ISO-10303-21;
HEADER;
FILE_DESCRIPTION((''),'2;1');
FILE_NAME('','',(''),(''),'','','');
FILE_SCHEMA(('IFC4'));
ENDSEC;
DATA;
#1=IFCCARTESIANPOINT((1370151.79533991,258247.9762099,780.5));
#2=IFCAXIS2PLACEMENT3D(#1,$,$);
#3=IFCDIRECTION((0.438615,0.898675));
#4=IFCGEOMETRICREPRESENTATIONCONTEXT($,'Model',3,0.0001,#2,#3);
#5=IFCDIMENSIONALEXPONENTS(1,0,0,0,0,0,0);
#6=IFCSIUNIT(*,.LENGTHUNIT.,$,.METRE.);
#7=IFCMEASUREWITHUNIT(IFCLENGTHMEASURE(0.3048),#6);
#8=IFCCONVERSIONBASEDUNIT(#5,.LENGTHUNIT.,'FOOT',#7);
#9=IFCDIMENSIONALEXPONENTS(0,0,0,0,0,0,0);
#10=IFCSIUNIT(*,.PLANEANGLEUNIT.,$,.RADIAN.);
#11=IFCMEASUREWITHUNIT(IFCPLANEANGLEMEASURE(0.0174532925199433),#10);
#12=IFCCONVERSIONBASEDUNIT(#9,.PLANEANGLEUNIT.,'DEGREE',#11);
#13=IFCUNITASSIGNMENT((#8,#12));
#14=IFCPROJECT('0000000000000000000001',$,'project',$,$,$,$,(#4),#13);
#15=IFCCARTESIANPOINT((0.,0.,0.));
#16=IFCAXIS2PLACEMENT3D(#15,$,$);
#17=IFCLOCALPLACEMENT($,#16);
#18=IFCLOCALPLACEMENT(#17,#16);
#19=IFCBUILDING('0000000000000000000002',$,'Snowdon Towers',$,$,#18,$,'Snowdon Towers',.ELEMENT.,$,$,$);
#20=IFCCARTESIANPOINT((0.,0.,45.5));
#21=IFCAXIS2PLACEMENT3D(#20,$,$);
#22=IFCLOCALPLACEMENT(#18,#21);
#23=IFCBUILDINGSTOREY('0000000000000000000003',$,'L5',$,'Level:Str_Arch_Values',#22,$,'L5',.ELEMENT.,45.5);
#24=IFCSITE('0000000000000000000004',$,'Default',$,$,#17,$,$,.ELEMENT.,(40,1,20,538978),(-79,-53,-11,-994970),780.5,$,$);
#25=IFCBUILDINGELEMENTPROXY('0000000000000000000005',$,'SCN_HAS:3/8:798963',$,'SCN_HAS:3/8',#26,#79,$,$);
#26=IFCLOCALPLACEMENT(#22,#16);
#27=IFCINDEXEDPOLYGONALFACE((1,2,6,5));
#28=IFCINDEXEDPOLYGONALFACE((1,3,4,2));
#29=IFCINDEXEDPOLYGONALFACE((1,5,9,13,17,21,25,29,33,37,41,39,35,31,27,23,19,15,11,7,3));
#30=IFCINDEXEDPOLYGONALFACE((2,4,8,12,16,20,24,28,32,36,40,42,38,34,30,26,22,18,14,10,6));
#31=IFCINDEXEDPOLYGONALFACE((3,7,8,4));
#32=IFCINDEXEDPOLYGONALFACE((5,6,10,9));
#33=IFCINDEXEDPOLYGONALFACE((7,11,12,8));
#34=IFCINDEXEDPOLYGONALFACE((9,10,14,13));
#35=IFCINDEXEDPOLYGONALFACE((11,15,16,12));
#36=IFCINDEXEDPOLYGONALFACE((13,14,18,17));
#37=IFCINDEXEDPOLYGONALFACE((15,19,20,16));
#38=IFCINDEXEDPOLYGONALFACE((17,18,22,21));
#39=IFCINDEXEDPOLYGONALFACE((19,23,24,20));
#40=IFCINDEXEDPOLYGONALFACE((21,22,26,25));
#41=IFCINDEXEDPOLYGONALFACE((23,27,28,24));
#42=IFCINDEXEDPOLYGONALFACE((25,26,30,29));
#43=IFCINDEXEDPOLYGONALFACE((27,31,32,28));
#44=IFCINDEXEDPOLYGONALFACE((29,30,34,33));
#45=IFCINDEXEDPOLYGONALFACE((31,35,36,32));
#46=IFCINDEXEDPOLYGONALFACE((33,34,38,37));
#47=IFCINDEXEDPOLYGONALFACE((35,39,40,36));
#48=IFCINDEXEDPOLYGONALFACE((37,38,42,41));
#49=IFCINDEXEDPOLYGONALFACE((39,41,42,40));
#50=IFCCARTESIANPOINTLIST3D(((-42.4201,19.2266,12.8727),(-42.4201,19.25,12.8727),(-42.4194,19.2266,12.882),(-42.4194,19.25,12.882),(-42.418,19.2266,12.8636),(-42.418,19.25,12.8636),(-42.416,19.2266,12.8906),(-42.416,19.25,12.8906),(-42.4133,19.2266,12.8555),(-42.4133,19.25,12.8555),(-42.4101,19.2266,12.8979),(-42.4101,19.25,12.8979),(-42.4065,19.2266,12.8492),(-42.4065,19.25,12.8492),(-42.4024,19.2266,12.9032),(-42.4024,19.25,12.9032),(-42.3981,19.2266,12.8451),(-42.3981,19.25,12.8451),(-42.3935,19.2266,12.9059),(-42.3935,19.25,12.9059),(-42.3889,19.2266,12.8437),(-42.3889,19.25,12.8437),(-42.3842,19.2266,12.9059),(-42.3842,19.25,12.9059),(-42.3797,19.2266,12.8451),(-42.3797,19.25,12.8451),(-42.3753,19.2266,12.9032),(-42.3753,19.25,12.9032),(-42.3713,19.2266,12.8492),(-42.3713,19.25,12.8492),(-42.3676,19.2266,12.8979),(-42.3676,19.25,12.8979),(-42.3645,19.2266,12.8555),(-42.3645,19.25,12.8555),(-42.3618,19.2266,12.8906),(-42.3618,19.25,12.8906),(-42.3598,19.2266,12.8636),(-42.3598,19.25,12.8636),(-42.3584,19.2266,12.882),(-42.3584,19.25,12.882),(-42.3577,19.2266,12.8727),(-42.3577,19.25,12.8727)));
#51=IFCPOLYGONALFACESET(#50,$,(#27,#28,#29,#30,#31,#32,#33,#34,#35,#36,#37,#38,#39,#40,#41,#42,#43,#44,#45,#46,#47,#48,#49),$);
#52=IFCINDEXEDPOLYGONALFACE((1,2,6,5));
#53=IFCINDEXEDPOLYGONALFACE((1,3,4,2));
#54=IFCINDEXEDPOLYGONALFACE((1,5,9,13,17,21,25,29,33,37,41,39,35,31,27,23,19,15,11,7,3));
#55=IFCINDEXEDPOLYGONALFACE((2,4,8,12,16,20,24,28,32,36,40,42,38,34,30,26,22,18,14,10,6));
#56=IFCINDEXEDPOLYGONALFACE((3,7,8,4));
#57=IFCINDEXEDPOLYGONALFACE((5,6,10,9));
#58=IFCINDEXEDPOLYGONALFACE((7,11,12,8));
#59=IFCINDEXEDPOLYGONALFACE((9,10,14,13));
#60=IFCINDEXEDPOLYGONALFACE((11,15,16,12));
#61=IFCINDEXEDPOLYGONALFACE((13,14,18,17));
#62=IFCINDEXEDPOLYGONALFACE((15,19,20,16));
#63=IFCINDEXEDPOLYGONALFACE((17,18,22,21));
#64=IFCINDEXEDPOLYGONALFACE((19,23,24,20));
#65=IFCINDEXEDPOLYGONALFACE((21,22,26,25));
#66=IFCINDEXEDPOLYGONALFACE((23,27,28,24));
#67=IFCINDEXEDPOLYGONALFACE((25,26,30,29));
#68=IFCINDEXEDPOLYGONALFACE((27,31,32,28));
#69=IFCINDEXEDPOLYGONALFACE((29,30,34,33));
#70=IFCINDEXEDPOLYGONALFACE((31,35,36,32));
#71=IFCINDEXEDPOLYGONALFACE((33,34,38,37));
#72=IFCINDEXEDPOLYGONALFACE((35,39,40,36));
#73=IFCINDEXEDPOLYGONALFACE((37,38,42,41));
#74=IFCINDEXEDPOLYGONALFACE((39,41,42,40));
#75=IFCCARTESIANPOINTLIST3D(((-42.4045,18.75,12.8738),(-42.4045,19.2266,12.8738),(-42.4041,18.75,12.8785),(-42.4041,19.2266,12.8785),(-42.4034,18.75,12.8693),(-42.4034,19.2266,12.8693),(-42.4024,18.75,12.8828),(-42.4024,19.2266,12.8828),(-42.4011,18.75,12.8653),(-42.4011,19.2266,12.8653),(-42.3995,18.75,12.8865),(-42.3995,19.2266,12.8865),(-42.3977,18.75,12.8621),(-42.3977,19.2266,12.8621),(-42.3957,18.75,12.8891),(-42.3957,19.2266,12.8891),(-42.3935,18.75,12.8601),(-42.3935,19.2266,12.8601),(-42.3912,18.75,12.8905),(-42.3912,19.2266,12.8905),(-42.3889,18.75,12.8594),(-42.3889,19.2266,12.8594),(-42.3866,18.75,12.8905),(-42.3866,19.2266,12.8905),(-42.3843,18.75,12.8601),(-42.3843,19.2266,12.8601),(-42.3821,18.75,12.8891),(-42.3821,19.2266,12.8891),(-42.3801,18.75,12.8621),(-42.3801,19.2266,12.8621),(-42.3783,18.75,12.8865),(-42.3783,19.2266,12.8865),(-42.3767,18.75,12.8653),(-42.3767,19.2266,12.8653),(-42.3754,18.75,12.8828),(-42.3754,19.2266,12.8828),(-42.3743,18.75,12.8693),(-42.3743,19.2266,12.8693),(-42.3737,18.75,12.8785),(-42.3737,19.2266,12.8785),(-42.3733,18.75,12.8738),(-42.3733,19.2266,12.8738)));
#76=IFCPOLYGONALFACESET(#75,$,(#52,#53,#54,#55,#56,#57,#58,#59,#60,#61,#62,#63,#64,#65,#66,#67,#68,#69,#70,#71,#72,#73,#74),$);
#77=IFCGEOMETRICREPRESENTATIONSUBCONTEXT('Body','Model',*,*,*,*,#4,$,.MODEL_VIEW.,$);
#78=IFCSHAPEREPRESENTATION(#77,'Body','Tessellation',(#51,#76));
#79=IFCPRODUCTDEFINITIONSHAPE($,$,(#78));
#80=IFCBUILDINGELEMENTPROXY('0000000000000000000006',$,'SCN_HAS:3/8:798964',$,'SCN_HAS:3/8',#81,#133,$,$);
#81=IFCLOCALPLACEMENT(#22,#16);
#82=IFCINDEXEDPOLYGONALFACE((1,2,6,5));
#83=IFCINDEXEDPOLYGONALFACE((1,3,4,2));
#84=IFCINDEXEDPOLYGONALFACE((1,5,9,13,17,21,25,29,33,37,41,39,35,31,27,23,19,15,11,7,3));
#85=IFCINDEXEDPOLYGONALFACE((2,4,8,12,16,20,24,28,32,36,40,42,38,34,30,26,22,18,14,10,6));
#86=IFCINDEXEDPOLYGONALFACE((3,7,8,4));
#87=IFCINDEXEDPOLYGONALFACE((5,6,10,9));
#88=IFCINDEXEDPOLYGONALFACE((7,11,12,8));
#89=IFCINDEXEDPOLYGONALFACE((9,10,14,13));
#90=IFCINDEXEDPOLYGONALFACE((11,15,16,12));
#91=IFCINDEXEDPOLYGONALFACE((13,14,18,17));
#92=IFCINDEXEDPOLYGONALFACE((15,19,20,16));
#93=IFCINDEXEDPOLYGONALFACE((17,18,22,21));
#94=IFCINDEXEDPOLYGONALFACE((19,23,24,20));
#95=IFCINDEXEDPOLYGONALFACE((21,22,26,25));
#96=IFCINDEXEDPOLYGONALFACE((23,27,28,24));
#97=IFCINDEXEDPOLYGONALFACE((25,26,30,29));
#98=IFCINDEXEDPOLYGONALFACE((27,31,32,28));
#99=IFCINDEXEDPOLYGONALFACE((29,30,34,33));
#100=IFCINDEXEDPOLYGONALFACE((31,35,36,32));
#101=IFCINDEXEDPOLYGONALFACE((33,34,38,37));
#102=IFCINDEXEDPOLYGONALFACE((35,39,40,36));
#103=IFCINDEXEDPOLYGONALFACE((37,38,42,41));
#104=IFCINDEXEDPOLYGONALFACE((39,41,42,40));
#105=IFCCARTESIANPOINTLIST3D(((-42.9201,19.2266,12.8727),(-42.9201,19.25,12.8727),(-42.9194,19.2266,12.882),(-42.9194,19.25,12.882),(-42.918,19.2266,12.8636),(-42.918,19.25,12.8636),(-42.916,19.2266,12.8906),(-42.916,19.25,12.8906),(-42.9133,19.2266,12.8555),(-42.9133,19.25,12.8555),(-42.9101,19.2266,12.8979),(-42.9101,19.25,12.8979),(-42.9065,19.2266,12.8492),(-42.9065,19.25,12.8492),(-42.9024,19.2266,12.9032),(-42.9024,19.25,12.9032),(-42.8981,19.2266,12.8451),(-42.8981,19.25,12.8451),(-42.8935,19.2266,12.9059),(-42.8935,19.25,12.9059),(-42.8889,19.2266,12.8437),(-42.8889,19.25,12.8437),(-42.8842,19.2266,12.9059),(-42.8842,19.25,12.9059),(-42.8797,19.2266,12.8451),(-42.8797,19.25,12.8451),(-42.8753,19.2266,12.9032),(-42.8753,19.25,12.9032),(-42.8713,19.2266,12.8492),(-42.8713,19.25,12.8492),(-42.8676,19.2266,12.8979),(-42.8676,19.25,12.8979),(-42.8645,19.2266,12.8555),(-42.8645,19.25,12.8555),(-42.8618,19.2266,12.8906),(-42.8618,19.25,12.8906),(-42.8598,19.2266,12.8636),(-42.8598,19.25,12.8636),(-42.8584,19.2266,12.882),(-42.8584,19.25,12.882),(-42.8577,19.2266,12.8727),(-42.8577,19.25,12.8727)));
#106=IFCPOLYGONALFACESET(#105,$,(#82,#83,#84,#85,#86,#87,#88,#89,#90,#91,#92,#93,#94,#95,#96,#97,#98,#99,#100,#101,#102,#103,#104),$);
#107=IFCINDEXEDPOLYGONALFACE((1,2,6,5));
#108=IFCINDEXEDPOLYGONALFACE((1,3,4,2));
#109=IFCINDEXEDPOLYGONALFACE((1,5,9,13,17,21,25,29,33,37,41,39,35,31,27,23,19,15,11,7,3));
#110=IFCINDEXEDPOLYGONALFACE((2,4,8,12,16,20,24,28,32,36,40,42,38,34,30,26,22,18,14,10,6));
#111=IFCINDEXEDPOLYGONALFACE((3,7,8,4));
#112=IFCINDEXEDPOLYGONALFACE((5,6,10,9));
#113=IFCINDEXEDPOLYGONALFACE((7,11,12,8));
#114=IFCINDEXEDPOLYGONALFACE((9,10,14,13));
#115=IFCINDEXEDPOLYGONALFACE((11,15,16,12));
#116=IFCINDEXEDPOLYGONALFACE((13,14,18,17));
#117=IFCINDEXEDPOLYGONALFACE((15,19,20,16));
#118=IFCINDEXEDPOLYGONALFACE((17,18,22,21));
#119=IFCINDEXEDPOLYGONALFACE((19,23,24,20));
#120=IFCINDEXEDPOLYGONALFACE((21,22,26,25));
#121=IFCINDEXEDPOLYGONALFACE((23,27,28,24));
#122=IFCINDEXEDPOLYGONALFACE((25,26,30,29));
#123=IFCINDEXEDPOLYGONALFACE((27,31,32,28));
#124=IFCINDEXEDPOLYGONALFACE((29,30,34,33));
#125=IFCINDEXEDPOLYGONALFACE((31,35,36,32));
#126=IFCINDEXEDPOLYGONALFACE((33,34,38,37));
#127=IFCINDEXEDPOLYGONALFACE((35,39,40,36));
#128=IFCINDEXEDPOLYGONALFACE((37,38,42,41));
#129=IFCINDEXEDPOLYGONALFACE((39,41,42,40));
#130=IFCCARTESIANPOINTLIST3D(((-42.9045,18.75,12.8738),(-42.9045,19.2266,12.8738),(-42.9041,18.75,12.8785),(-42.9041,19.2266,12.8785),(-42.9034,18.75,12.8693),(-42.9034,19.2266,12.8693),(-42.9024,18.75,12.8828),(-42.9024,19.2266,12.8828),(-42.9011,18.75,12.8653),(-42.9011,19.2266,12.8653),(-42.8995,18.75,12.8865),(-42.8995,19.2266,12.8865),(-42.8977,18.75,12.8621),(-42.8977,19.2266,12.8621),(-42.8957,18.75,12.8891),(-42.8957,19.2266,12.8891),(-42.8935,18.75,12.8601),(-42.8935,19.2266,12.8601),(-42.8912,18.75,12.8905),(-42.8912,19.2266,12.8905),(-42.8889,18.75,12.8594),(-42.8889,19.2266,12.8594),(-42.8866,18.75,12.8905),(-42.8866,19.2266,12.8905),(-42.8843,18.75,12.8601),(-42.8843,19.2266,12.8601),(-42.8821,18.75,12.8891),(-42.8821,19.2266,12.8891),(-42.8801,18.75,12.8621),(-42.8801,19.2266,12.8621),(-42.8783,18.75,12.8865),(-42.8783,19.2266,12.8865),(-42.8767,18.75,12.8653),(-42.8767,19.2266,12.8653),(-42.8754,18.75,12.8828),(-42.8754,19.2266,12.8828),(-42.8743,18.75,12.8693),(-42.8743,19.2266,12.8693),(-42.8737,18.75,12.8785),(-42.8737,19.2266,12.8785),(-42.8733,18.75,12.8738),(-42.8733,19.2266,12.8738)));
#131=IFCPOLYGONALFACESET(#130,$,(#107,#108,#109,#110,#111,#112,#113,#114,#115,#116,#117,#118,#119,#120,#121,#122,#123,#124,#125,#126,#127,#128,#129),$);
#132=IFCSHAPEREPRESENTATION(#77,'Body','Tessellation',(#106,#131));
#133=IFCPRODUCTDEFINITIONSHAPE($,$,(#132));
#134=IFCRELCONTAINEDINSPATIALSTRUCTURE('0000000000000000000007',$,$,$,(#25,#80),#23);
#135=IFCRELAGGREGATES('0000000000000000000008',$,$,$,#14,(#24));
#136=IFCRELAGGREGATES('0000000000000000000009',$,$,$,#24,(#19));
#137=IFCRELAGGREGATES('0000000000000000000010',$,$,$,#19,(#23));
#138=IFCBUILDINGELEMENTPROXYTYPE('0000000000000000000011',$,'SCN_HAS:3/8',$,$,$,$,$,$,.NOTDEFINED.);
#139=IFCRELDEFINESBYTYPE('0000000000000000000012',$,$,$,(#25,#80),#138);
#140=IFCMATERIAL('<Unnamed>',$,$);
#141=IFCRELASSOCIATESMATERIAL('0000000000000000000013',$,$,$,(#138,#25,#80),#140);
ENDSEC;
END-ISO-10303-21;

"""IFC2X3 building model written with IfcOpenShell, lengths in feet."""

from ifc_helpers import new_model, entity, si_unit, converted_unit, direction, frame, frame_2d, origin, place, context, subcontext, project, spatial, circle, extrude, source, transform, mapped, material, type_object, type_shapes, element, save


model = new_model("IFC2X3")

# Units and contexts
model_context = context("Model", 3, precision=0.0001, world=frame((1370151.79533991, 258247.9762099, 780.5)), true_north=direction((0.438615, 0.898675)))
body_context = subcontext(model_context, "Body", "Model", "MODEL_VIEW")
ifc_project = project(units=[converted_unit("LENGTHUNIT", "FOOT", entity("IfcLengthMeasure", 0.3048), si_unit("LENGTHUNIT", "METRE"), dimensions=[1, 0, 0, 0, 0, 0, 0]), converted_unit("PLANEANGLEUNIT", "DEGREE", entity("IfcPlaneAngleMeasure", 0.0174532925199433), si_unit("PLANEANGLEUNIT", "RADIAN"), dimensions=[0, 0, 0, 0, 0, 0, 0])], contexts=[model_context])

# Site, building, storey
site_placement = place(None, origin())
site = spatial("IfcSite", under=ifc_project, at=site_placement, Name="Default", CompositionType="ELEMENT", RefLatitude=(40, 1, 20, 538978), RefLongitude=(-79, -53, -11, -994970), RefElevation=780.5)
building_placement = place(site_placement, origin())
building = spatial("IfcBuilding", under=site, at=building_placement, Name="Snowdon Towers", LongName="Snowdon Towers", CompositionType="ELEMENT")
storey_placement = place(building_placement, frame((0.0, 0.0, 45.5)))
storey = spatial("IfcBuildingStorey", under=building, at=storey_placement, Name="L5", ObjectType="Level:Str_Arch_Values", LongName="L5", CompositionType="ELEMENT", Elevation=45.5)

# Building element proxies
ifc_material_1 = material(Name="<Unnamed>")
building_element_proxy_type = type_object("IfcBuildingElementProxyType", Name="SCN_HAS:3/8", PredefinedType="NOTDEFINED", material=ifc_material_1)
shared_shape = source(origin(), body_context, "Body", "SweptSolid", [
    extrude(circle(Radius=0.0312, at=frame_2d((0.0, 0.0), x_axis=(1.0, 0.0))), frame((0.0, 0.0, -0.5), z_axis=(0.0, 0.0, 1.0), x_axis=(0.0, -1.0, 0.0)), (0.0, 0.0, 1.0), 0.0234),
    extrude(circle(Radius=0.0156, at=frame_2d((0.0, 0.0), x_axis=(1.0, 0.0))), frame((0.0, 0.0, -0.4766), z_axis=(0.0, 0.0, 1.0), x_axis=(0.0, -1.0, 0.0)), (0.0, 0.0, 1.0), 0.4766),
])
type_shapes(building_element_proxy_type, [shared_shape])
for number, where, z_axis, x_axis, name in (
    (1, (-42.3889, 18.75, 12.875), (0.0, -1.0, 0.0), (1.0, 0.0, 0.0), "SCN_HAS:3/8:798963"),
    (2, (-42.8889, 18.75, 12.875), (0.0, -1.0, 0.0), (1.0, 0.0, 0.0), "SCN_HAS:3/8:798964"),
):
    element("IfcBuildingElementProxy", number, at=place(storey_placement, frame(where, z_axis=z_axis, x_axis=x_axis)), inside=storey, type_object=building_element_proxy_type, material=ifc_material_1, Name=name, ObjectType="SCN_HAS:3/8", context=body_context, shape_type="MappedRepresentation", body=[
        mapped(shared_shape, transform((0.0, 0.0, 0.0), scale=1.0)),
    ])

save(model, "model.ifc")
